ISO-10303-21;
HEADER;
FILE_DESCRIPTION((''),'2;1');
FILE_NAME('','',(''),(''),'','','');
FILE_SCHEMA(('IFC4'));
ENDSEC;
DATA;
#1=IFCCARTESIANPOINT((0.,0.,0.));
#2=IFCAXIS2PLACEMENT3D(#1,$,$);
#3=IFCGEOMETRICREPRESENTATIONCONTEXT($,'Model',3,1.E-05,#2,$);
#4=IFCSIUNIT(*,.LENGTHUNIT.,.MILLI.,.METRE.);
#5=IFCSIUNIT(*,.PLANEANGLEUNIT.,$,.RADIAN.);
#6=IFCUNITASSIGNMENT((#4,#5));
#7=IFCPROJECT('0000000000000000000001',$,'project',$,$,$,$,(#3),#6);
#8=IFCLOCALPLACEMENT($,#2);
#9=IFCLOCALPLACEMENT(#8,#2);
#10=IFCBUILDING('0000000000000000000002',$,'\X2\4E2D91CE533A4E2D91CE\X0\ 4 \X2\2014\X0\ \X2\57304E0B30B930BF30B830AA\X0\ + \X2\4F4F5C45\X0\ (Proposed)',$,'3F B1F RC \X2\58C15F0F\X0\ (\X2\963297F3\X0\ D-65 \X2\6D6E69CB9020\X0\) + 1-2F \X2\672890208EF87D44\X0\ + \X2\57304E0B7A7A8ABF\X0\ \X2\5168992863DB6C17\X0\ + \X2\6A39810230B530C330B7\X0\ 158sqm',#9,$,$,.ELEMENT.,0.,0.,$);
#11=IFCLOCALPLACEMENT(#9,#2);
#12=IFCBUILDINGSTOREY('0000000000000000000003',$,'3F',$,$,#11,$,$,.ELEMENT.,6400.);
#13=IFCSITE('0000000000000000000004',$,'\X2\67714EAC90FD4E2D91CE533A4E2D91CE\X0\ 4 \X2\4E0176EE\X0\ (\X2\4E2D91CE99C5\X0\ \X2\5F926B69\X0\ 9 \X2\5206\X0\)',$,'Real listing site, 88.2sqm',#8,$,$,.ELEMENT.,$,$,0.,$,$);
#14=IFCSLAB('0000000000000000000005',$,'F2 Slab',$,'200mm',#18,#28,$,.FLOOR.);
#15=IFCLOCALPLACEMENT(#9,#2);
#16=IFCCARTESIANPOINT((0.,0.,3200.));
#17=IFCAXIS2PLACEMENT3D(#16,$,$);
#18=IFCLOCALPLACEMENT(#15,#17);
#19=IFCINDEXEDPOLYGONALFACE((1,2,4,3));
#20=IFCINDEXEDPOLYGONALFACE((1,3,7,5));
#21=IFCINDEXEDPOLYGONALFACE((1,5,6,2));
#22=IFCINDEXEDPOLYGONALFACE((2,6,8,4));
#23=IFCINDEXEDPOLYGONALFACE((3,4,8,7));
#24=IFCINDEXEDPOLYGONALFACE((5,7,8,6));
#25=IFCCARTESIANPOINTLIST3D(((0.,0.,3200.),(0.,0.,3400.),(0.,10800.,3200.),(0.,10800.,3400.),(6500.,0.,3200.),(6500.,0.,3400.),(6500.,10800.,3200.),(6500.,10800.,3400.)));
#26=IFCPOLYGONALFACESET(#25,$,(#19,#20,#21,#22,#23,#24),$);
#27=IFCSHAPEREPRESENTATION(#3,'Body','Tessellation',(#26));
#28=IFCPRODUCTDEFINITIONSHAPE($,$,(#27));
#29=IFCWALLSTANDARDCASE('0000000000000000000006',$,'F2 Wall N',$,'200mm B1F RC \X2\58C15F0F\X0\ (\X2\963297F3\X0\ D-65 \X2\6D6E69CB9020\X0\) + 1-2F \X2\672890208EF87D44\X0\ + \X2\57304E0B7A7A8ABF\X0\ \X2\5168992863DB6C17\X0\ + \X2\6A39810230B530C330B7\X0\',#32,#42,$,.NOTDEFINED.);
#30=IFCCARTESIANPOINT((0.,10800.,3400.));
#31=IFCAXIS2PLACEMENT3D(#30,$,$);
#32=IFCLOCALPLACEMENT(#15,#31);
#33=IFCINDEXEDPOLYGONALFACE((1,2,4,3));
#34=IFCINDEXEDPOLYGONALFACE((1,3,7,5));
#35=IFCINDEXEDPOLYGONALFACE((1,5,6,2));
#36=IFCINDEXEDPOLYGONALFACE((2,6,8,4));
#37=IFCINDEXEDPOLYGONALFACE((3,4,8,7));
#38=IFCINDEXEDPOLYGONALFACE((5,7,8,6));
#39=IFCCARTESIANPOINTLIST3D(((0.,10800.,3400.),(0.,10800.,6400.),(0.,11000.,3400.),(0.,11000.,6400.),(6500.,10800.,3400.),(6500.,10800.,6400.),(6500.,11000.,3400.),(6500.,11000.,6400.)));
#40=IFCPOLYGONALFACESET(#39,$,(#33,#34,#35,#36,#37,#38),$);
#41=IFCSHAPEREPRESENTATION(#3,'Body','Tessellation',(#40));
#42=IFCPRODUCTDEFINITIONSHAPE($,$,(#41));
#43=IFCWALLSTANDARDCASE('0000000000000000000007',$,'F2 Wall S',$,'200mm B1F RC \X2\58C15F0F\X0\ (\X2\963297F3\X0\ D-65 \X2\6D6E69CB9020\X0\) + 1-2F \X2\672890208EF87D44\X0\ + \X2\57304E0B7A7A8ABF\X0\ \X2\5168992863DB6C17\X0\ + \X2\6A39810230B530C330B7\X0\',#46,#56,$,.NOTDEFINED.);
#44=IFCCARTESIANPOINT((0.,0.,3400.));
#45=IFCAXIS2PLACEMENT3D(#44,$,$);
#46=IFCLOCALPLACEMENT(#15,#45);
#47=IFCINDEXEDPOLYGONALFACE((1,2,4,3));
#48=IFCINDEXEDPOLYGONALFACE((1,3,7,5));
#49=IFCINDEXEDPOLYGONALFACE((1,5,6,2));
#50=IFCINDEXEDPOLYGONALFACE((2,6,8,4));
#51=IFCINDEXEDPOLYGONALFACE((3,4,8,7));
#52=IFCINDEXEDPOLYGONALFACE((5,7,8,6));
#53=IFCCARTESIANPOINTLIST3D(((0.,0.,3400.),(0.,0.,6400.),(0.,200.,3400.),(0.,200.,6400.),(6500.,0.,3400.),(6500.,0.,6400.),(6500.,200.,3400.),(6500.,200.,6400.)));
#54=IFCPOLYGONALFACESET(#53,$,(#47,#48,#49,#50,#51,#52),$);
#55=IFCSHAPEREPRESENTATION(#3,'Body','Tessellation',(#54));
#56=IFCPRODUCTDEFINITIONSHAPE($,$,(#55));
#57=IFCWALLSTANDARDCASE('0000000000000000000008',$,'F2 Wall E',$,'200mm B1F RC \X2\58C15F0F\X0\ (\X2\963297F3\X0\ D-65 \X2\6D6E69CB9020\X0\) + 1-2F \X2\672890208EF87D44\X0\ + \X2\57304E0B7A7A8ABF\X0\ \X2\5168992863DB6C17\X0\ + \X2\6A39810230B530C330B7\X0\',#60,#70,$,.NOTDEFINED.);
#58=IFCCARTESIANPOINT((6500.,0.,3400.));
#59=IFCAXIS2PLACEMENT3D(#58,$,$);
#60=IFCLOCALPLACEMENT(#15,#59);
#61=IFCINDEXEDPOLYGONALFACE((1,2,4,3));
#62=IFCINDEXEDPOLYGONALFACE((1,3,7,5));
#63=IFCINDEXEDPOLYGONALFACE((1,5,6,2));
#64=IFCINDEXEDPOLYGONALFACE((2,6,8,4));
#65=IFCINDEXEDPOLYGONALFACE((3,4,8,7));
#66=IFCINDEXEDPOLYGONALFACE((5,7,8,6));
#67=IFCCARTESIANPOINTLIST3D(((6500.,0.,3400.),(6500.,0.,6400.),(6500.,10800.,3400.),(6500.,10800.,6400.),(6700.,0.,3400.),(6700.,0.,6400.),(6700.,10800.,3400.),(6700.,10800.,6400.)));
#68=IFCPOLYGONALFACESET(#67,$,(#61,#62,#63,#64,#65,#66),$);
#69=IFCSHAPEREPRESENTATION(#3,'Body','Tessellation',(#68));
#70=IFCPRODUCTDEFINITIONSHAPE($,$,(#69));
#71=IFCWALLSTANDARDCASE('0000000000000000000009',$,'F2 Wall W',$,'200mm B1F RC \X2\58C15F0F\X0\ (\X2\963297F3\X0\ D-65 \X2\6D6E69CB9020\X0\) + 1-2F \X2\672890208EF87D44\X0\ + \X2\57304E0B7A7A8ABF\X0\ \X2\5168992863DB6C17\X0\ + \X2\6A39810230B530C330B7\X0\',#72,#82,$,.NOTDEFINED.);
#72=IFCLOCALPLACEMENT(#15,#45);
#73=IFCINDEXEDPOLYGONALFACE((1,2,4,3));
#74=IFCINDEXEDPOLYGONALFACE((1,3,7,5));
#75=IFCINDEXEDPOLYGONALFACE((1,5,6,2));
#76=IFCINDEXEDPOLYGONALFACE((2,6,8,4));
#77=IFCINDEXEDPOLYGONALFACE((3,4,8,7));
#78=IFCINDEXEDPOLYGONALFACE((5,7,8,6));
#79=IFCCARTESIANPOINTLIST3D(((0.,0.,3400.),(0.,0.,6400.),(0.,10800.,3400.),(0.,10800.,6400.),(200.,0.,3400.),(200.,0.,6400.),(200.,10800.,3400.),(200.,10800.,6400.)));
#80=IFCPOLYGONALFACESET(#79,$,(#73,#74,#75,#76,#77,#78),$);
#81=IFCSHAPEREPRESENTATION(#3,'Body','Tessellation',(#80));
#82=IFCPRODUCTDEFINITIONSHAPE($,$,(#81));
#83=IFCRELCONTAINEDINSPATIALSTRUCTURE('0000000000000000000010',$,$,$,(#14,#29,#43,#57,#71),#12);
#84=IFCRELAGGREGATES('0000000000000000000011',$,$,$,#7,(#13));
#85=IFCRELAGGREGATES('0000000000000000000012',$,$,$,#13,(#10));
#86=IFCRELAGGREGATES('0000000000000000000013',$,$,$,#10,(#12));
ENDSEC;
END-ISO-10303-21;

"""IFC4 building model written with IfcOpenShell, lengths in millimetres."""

from ifc_helpers import new_model, si_unit, frame, frame_2d, origin, place, context, project, spatial, rectangle, extrude, element, save


model = new_model("IFC4")

# Units and contexts
model_context = context("Model", 3, precision=1e-05, world=origin())
ifc_project = project(units=[si_unit("LENGTHUNIT", "METRE", prefix="MILLI"), si_unit("PLANEANGLEUNIT", "RADIAN")], contexts=[model_context])

# Site, building, storey
site_placement = place(None, origin())
site = spatial("IfcSite", under=ifc_project, at=site_placement, Name="東京都中野区中野 4 丁目 (中野駅 徒歩 9 分)", ObjectType="Real listing site, 88.2sqm", CompositionType="ELEMENT", RefElevation=0.0)
building_placement = place(site_placement, origin())
building = spatial("IfcBuilding", under=site, at=building_placement, Name="中野区中野 4 — 地下スタジオ + 住居 (Proposed)", ObjectType="3F B1F RC 壁式 (防音 D-65 浮構造) + 1-2F 木造軸組 + 地下空調 全館換気 + 樹脂サッシ 158sqm", CompositionType="ELEMENT", ElevationOfRefHeight=0.0, ElevationOfTerrain=0.0)
storey_placement = place(building_placement, origin())
storey = spatial("IfcBuildingStorey", under=building, at=storey_placement, Name="3F", CompositionType="ELEMENT", Elevation=6400.0)

# Slab
placement = place(building_placement, origin())
slab_placement = place(placement, frame((0.0, 0.0, 3200.0)))
element("IfcSlab", 1, at=slab_placement, inside=storey, Name="F2 Slab", ObjectType="200mm", PredefinedType="FLOOR", context=model_context, shape_type="SweptSolid", body=[
    extrude(rectangle(XDim=6500.0, YDim=10800.0, at=frame_2d((3250.0, 5400.0))), frame((0.0, 0.0, 3200.0)), (0.0, 0.0, 1.0), 200.0),
])

# Walls
wall_1_placement = place(placement, frame((0.0, 10800.0, 3400.0)))
element("IfcWallStandardCase", 2, at=wall_1_placement, inside=storey, Name="F2 Wall N", ObjectType="200mm B1F RC 壁式 (防音 D-65 浮構造) + 1-2F 木造軸組 + 地下空調 全館換気 + 樹脂サッシ", PredefinedType="NOTDEFINED", context=model_context, shape_type="SweptSolid", body=[
    extrude(rectangle(XDim=6500.0, YDim=200.0, at=frame_2d((3250.0, 100.0))), frame((0.0, 10800.0, 3400.0)), (0.0, 0.0, 1.0), 3000.0),
])
wall_2_placement = place(placement, frame((0.0, 0.0, 3400.0)))
element("IfcWallStandardCase", 3, at=wall_2_placement, inside=storey, Name="F2 Wall S", ObjectType="200mm B1F RC 壁式 (防音 D-65 浮構造) + 1-2F 木造軸組 + 地下空調 全館換気 + 樹脂サッシ", PredefinedType="NOTDEFINED", context=model_context, shape_type="SweptSolid", body=[
    extrude(rectangle(XDim=6500.0, YDim=200.0, at=frame_2d((3250.0, 100.0))), frame((0.0, 0.0, 3400.0)), (0.0, 0.0, 1.0), 3000.0),
])
wall_3_placement = place(placement, frame((6500.0, 0.0, 3400.0)))
element("IfcWallStandardCase", 4, at=wall_3_placement, inside=storey, Name="F2 Wall E", ObjectType="200mm B1F RC 壁式 (防音 D-65 浮構造) + 1-2F 木造軸組 + 地下空調 全館換気 + 樹脂サッシ", PredefinedType="NOTDEFINED", context=model_context, shape_type="SweptSolid", body=[
    extrude(rectangle(XDim=200.0, YDim=10800.0, at=frame_2d((100.0, 5400.0))), frame((6500.0, 0.0, 3400.0)), (0.0, 0.0, 1.0), 3000.0),
])
wall_4_placement = place(placement, frame((0.0, 0.0, 3400.0)))
element("IfcWallStandardCase", 5, at=wall_4_placement, inside=storey, Name="F2 Wall W", ObjectType="200mm B1F RC 壁式 (防音 D-65 浮構造) + 1-2F 木造軸組 + 地下空調 全館換気 + 樹脂サッシ", PredefinedType="NOTDEFINED", context=model_context, shape_type="SweptSolid", body=[
    extrude(rectangle(XDim=200.0, YDim=10800.0, at=frame_2d((100.0, 5400.0))), frame((0.0, 0.0, 3400.0)), (0.0, 0.0, 1.0), 3000.0),
])

save(model, "model.ifc")
